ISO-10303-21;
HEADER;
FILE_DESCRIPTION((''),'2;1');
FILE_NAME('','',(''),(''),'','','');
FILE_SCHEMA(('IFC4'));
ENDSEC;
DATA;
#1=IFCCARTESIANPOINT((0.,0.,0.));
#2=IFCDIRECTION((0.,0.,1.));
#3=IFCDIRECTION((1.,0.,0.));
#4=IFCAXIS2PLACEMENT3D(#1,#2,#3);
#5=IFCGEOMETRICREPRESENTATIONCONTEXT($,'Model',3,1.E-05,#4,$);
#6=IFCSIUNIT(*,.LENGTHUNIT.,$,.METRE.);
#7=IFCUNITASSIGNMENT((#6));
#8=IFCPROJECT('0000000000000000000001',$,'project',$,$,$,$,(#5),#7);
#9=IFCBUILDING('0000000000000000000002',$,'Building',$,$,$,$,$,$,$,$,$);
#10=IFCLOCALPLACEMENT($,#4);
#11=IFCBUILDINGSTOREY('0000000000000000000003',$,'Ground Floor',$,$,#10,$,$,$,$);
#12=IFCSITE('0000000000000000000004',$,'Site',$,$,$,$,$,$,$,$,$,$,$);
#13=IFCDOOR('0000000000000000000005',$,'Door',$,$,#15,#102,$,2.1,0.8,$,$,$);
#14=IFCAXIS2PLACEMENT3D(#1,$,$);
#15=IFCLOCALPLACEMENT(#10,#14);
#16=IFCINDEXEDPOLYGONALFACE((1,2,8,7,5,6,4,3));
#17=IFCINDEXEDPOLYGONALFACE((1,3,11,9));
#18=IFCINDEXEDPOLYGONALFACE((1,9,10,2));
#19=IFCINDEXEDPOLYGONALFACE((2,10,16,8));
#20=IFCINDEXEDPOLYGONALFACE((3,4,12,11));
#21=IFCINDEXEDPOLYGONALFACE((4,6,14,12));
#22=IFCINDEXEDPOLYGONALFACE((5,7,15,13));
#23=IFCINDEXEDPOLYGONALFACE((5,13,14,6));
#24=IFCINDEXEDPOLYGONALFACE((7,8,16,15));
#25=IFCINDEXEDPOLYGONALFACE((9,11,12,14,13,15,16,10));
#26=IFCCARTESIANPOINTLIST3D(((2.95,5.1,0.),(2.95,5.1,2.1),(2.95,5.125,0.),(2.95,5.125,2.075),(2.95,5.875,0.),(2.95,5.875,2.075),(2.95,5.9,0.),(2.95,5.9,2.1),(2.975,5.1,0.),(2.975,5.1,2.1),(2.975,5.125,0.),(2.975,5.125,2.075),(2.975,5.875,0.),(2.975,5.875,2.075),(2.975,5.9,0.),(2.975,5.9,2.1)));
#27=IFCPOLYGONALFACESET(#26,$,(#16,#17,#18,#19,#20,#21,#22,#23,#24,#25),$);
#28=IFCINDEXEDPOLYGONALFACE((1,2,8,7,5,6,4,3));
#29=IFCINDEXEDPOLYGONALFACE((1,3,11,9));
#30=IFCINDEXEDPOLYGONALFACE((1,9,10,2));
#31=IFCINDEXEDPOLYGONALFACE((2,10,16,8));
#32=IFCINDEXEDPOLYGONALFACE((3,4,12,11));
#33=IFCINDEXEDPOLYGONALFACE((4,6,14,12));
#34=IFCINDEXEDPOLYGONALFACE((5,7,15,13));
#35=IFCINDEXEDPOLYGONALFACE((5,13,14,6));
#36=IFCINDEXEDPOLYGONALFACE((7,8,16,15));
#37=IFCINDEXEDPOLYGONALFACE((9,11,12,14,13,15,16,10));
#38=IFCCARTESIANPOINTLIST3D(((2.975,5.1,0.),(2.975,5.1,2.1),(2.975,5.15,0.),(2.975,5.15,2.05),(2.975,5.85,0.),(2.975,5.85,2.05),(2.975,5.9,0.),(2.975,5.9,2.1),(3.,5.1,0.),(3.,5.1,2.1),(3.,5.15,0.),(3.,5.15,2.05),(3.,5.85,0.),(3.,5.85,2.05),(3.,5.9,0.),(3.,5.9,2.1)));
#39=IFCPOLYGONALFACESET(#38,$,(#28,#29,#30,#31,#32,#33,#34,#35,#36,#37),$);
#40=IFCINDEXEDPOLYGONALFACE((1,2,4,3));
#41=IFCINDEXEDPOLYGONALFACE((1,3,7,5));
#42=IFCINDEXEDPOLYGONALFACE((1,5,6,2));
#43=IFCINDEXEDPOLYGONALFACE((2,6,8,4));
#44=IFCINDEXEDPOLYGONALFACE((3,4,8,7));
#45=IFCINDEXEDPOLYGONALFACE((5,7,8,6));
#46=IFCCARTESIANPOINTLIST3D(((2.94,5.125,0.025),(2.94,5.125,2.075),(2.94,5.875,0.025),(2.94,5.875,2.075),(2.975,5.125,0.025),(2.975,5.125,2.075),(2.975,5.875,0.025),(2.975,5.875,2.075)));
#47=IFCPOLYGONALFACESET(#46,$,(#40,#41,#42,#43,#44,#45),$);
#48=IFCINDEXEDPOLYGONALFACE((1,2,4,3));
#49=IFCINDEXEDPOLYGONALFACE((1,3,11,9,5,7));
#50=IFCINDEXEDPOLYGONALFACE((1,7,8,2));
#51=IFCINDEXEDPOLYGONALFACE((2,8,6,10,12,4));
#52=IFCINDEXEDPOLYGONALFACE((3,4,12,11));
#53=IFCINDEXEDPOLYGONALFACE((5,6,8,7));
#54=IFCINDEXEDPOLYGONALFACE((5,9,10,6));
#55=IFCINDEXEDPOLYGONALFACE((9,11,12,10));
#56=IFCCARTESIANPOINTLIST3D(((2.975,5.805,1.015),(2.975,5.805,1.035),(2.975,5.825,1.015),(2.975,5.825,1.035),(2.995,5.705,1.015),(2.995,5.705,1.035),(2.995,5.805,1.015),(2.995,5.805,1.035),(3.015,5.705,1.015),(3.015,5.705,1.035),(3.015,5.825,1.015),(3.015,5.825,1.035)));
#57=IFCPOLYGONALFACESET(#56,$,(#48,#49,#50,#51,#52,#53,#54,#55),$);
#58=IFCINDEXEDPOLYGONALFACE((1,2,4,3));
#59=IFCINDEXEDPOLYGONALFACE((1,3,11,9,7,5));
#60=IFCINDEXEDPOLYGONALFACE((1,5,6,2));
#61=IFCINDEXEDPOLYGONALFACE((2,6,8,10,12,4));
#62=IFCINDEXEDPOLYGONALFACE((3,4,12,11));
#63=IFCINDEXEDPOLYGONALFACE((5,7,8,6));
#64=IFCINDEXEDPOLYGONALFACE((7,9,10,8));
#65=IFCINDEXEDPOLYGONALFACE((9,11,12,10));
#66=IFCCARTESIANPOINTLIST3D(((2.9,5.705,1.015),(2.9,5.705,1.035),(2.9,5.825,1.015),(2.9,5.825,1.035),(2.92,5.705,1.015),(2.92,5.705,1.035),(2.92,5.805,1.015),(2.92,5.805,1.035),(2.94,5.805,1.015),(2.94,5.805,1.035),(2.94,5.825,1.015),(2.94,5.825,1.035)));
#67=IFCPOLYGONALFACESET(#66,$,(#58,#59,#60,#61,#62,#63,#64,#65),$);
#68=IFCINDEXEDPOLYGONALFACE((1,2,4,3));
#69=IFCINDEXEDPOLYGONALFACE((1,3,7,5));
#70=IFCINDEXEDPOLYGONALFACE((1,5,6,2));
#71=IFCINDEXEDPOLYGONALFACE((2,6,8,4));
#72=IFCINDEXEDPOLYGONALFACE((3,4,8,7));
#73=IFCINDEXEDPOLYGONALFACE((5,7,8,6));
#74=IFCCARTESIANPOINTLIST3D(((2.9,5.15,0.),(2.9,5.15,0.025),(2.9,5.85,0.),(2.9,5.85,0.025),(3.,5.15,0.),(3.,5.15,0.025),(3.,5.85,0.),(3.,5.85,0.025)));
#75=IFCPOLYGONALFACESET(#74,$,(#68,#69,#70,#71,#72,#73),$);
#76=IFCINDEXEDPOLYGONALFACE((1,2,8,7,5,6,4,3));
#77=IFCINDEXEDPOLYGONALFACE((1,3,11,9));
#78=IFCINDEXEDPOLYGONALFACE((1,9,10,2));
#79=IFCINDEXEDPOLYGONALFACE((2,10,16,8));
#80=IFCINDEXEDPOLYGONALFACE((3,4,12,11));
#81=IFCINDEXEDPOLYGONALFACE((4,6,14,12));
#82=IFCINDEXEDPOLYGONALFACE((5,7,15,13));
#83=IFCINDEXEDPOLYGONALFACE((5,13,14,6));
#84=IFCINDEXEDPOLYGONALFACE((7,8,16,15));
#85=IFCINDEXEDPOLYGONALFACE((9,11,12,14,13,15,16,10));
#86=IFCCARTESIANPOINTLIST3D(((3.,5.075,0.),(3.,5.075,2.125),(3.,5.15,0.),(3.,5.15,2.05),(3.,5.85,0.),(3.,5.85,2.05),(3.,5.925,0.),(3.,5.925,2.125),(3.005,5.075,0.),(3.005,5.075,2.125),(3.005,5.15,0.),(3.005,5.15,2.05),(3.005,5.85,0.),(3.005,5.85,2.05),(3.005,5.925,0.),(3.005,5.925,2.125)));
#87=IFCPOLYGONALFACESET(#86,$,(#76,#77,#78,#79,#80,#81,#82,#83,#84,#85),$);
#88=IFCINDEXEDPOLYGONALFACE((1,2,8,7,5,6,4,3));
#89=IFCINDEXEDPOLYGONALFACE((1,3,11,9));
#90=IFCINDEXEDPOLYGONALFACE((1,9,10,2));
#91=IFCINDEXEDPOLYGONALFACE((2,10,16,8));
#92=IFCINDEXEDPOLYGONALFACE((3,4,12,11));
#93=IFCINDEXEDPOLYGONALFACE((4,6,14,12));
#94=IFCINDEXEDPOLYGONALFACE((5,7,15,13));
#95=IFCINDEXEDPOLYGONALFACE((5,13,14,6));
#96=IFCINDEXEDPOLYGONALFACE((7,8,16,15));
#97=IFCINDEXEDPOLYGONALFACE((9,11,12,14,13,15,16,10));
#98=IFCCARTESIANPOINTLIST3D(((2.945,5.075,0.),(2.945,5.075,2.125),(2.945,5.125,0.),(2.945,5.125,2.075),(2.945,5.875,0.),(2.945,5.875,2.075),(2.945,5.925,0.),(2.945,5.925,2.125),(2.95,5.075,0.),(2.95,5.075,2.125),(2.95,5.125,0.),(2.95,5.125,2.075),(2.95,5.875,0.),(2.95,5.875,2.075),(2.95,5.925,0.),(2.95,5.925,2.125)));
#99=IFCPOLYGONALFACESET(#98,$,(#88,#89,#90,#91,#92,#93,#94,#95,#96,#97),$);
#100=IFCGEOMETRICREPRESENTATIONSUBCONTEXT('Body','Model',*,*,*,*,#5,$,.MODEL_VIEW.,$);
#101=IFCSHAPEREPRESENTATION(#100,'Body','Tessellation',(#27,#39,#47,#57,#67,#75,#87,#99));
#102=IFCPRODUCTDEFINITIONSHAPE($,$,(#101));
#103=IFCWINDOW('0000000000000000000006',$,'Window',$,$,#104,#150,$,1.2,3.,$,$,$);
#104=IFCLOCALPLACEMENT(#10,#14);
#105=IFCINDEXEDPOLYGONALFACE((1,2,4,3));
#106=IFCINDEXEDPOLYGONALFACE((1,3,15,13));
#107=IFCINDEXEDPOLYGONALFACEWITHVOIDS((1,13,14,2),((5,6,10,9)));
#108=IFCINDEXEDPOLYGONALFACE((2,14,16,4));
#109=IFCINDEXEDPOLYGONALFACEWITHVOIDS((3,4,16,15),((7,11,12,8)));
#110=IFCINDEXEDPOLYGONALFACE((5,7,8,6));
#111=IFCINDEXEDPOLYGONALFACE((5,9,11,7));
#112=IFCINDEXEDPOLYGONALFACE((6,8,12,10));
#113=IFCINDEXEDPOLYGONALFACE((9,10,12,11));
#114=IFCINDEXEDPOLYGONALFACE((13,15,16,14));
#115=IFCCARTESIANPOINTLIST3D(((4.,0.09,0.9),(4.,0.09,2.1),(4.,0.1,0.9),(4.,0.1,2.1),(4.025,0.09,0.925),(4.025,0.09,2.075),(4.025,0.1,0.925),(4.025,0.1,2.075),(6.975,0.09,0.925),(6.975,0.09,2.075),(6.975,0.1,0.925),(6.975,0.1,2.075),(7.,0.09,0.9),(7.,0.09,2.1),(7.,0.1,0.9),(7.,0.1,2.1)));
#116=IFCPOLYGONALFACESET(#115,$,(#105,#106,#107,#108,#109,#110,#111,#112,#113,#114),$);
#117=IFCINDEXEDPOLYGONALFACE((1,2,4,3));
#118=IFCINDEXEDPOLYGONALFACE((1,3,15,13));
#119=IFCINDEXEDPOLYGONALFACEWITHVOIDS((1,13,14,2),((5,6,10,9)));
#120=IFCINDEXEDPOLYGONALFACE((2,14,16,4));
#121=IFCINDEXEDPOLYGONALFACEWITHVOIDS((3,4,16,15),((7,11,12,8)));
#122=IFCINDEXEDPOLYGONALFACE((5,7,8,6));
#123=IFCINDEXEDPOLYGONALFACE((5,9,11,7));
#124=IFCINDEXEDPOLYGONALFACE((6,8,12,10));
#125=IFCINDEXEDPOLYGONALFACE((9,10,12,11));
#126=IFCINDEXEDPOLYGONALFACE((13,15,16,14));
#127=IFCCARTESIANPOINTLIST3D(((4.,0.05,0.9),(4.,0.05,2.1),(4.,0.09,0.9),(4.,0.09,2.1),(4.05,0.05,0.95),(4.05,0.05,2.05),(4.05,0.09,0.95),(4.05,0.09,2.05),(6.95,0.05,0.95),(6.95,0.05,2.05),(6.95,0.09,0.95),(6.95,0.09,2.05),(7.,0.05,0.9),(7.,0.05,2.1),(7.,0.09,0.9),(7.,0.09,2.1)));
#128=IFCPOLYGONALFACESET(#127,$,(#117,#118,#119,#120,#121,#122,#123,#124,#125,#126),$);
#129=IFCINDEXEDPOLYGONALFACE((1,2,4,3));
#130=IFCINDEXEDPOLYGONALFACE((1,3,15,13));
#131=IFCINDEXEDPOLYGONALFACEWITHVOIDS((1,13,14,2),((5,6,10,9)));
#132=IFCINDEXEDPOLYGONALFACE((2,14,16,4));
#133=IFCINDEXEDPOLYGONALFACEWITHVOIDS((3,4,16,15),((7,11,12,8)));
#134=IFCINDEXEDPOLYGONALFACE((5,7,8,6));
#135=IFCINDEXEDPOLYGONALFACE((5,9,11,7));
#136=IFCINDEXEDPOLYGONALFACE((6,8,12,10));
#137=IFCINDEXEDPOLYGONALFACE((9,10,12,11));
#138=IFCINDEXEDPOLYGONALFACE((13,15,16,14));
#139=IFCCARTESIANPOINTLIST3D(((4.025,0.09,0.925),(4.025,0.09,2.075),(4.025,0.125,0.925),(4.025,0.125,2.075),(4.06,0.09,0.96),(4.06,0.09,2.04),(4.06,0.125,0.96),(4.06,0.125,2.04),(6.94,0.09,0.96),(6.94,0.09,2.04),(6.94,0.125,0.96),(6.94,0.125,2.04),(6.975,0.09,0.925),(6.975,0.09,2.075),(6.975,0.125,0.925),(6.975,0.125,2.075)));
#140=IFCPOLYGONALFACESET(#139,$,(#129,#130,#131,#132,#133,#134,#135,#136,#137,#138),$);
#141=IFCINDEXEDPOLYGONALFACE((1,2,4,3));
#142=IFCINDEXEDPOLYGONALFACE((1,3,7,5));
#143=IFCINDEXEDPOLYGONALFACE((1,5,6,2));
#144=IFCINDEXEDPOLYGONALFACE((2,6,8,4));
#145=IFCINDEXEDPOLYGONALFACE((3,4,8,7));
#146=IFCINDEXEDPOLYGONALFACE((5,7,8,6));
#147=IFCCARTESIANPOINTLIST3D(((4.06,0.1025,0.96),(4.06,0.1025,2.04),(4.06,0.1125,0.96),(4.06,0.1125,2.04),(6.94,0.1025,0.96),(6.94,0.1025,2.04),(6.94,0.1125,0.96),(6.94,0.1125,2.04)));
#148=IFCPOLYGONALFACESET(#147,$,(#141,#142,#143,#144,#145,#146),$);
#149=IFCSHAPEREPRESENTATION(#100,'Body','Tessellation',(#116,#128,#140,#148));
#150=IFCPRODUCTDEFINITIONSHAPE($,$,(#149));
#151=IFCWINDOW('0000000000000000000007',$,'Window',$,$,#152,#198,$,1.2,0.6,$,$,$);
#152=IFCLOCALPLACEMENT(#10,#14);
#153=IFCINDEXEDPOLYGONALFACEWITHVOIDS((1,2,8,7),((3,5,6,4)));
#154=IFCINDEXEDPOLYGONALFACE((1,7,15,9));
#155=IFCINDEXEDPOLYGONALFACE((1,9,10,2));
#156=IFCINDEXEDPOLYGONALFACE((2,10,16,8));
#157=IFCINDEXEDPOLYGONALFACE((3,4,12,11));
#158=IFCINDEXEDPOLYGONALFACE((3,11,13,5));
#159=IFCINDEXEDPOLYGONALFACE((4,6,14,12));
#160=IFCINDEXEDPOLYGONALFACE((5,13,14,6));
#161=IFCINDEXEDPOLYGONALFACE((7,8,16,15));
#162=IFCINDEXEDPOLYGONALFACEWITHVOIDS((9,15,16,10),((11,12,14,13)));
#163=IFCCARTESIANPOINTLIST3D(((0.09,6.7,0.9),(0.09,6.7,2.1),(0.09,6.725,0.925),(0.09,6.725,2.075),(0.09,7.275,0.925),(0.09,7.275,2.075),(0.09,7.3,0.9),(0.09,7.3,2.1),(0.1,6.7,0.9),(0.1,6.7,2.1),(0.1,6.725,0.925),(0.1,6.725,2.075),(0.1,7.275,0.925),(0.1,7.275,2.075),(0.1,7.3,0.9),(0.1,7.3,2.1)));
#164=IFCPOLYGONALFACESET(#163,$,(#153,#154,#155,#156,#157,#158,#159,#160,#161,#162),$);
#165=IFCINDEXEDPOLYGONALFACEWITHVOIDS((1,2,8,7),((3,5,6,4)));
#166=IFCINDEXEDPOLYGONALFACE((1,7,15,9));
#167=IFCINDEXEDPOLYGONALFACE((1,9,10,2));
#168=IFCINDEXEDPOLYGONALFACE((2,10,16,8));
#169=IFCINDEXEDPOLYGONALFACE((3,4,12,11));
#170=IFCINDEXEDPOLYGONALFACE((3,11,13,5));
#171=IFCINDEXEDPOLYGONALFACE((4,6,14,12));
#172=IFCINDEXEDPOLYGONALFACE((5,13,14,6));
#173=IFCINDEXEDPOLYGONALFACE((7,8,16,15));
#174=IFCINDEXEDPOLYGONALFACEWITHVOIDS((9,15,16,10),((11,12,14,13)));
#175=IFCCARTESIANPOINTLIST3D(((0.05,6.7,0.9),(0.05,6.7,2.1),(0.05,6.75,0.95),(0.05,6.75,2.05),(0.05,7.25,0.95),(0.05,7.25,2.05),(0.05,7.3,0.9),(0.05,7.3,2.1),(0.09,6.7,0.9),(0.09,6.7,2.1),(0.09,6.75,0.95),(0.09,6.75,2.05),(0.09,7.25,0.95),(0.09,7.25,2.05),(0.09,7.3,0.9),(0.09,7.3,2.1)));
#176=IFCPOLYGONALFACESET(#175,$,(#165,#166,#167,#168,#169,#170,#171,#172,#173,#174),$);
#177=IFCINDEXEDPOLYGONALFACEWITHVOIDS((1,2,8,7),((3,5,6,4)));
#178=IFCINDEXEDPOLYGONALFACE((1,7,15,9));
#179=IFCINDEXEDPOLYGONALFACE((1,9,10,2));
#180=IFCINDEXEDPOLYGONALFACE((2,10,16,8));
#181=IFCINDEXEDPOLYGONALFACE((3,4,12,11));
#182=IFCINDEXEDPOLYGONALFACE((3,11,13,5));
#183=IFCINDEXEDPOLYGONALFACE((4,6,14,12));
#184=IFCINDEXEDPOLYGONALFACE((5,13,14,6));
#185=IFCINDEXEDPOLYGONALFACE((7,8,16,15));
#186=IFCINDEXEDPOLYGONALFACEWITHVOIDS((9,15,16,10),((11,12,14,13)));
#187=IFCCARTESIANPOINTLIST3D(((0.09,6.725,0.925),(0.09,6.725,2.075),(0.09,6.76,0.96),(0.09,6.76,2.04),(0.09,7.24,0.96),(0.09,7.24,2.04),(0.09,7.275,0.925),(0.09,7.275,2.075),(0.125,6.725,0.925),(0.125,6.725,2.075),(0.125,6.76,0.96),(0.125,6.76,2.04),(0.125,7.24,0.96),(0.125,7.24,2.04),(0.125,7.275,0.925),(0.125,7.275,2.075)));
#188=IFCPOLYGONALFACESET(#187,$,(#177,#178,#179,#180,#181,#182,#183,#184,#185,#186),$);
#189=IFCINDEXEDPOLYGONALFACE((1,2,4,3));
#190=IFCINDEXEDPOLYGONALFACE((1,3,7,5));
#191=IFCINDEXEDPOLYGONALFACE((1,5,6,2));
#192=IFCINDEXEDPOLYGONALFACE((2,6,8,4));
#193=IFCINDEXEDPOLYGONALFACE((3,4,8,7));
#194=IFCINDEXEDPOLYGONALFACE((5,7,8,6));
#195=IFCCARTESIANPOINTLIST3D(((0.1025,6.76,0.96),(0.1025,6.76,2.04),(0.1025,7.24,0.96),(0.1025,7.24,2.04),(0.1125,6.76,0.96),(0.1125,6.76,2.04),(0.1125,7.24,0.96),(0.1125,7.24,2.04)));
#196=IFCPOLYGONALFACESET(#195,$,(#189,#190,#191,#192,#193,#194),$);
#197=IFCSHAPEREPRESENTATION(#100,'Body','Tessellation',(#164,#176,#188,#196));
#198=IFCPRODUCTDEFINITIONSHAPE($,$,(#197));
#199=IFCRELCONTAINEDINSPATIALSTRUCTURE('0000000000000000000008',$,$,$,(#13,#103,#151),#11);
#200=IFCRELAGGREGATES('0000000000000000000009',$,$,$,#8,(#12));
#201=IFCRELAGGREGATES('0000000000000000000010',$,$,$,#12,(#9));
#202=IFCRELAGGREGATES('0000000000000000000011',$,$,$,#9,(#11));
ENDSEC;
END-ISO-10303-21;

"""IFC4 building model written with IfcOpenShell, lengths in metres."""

from ifc_helpers import new_model, si_unit, frame, origin_with_axes, place, context, subcontext, project, spatial, line, indexed_curve, outline, extrude, element, save


model = new_model("IFC4")

# Units and contexts
model_context = context("Model", 3, precision=1e-05, world=origin_with_axes())
body_context = subcontext(model_context, "Body", "Model", "MODEL_VIEW")
ifc_project = project(units=[si_unit("LENGTHUNIT", "METRE")], contexts=[model_context])

# Site, building, storey
site = spatial("IfcSite", under=ifc_project, Name="Site")
building = spatial("IfcBuilding", under=site, Name="Building")
storey_placement = place(None, origin_with_axes())
storey = spatial("IfcBuildingStorey", under=building, at=storey_placement, Name="Ground Floor")

# Door
door_1_placement = place(storey_placement, frame((3.0, 5.1, 0.0), z_axis=(0.0, 0.0, 1.0), x_axis=(0.0, 1.0, 0.0)))
element("IfcDoor", 1, at=door_1_placement, inside=storey, Name="Door", OverallHeight=2.1, OverallWidth=0.8, context=body_context, shape_type="SweptSolid", body=[
    extrude(outline(indexed_curve([(0.0, 0.0), (0.0, 2.1), (0.8, 2.1), (0.8, 0.0), (0.775, 0.0), (0.775, 2.075), (0.025, 2.075), (0.025, 0.0)], segments=[line(1, 2, 3, 4, 5, 6, 7, 8, 1)])), frame((0.0, 0.025, 0.0), z_axis=(0.0, -1.0, 0.0), x_axis=(1.0, 0.0, 0.0)), (0.0, 0.0, -1.0), 0.025),
    extrude(outline(indexed_curve([(0.0, 0.0), (0.0, 2.1), (0.8, 2.1), (0.8, 0.0), (0.75, 0.0), (0.75, 2.05), (0.05, 2.05), (0.05, 0.0)], segments=[line(1, 2, 3, 4, 5, 6, 7, 8, 1)])), frame((0.0, 0.0, 0.0), z_axis=(0.0, -1.0, 0.0), x_axis=(1.0, 0.0, 0.0)), (0.0, 0.0, -1.0), 0.025),
    extrude(outline(indexed_curve([(0.0, 0.0), (0.75, 0.0), (0.75, 0.035), (0.0, 0.035)], segments=[line(1, 2, 3, 4, 1)])), frame((0.025, 0.025, 0.025), z_axis=(0.0, 0.0, 1.0), x_axis=(1.0, 0.0, 0.0)), (0.0, 0.0, 1.0), 2.05),
    extrude(outline(indexed_curve([(0.0, 0.0), (0.0, -0.04), (-0.12, -0.04), (-0.12, -0.02), (-0.02, -0.02), (-0.02, 0.0)], segments=[line(1, 2, 3, 4, 5, 6, 1)])), frame((0.725, 0.025, 1.015), z_axis=(0.0, 0.0, 1.0), x_axis=(1.0, 0.0, 0.0)), (0.0, 0.0, 1.0), 0.02),
    extrude(outline(indexed_curve([(0.0, 0.0), (0.0, 0.04), (-0.12, 0.04), (-0.12, 0.02), (-0.02, 0.02), (-0.02, 0.0)], segments=[line(1, 2, 3, 4, 5, 6, 1)])), frame((0.725, 0.06, 1.015), z_axis=(0.0, 0.0, 1.0), x_axis=(1.0, 0.0, 0.0)), (0.0, 0.0, 1.0), 0.02),
    extrude(outline(indexed_curve([(0.0, 0.0), (0.7, 0.0), (0.7, 0.1), (0.0, 0.1)], segments=[line(1, 2, 3, 4, 1)])), frame((0.05, 0.0, 0.0), z_axis=(0.0, 0.0, 1.0), x_axis=(1.0, 0.0, 0.0)), (0.0, 0.0, 1.0), 0.025),
    extrude(outline(indexed_curve([(0.0, 0.0), (0.0, 2.125), (0.85, 2.125), (0.85, 0.0), (0.775, 0.0), (0.775, 2.05), (0.075, 2.05), (0.075, 0.0)], segments=[line(1, 2, 3, 4, 5, 6, 7, 8, 1)])), frame((-0.025, -0.005, 0.0), z_axis=(0.0, -1.0, 0.0), x_axis=(1.0, 0.0, 0.0)), (0.0, 0.0, -1.0), 0.005),
    extrude(outline(indexed_curve([(0.0, 0.0), (0.0, 2.125), (0.85, 2.125), (0.85, 0.0), (0.8, 0.0), (0.8, 2.075), (0.05, 2.075), (0.05, 0.0)], segments=[line(1, 2, 3, 4, 5, 6, 7, 8, 1)])), frame((-0.025, 0.05, 0.0), z_axis=(0.0, -1.0, 0.0), x_axis=(1.0, 0.0, 0.0)), (0.0, 0.0, -1.0), 0.005),
])

# Windows
window_1_placement = place(storey_placement, frame((4.0, 0.0, 0.9), z_axis=(0.0, 0.0, 1.0), x_axis=(1.0, 0.0, 0.0)))
element("IfcWindow", 2, at=window_1_placement, inside=storey, Name="Window", OverallHeight=1.2, OverallWidth=3.0, context=body_context, shape_type="SweptSolid", body=[
    extrude(outline(indexed_curve([(0.0, 0.0), (3.0, 0.0), (3.0, 1.2), (0.0, 1.2)], segments=[line(1, 2, 3, 4, 1)]), holes=[indexed_curve([(0.025, 0.025), (2.975, 0.025), (2.975, 1.175), (0.025, 1.175)], segments=[line(1, 2, 3, 4, 1)])]), frame((0.0, 0.09, 0.0), z_axis=(0.0, -1.0, 0.0), x_axis=(1.0, 0.0, 0.0)), (0.0, 0.0, -1.0), 0.01),
    extrude(outline(indexed_curve([(0.0, 0.0), (3.0, 0.0), (3.0, 1.2), (0.0, 1.2)], segments=[line(1, 2, 3, 4, 1)]), holes=[indexed_curve([(0.05, 0.05), (2.95, 0.05), (2.95, 1.15), (0.05, 1.15)], segments=[line(1, 2, 3, 4, 1)])]), frame((0.0, 0.05, 0.0), z_axis=(0.0, -1.0, 0.0), x_axis=(1.0, 0.0, 0.0)), (0.0, 0.0, -1.0), 0.04),
    extrude(outline(indexed_curve([(0.0, 0.0), (2.95, 0.0), (2.95, 1.15), (0.0, 1.15)], segments=[line(1, 2, 3, 4, 1)]), holes=[indexed_curve([(0.035, 0.035), (2.915, 0.035), (2.915, 1.115), (0.035, 1.115)], segments=[line(1, 2, 3, 4, 1)])]), frame((0.025, 0.09, 0.025), z_axis=(0.0, -1.0, 0.0), x_axis=(1.0, 0.0, 0.0)), (0.0, 0.0, -1.0), 0.035),
    extrude(outline(indexed_curve([(0.035, 0.035), (2.915, 0.035), (2.915, 1.115), (0.035, 1.115)], segments=[line(1, 2, 3, 4, 1)])), frame((0.025, 0.1025, 0.025), z_axis=(0.0, -1.0, 0.0), x_axis=(1.0, 0.0, 0.0)), (0.0, 0.0, -1.0), 0.01),
])
for number, where, z_axis, x_axis, name in (
    (3, (0.0, 7.3, 0.9), (0.0, 0.0, 1.0), (0.0, -1.0, 0.0), "Window"),
):
    element("IfcWindow", number, at=place(storey_placement, frame(where, z_axis=z_axis, x_axis=x_axis)), inside=storey, Name=name, OverallHeight=1.2, OverallWidth=0.6, context=body_context, shape_type="SweptSolid", body=[
        extrude(outline(indexed_curve([(0.0, 0.0), (0.6, 0.0), (0.6, 1.2), (0.0, 1.2)], segments=[line(1, 2, 3, 4, 1)]), holes=[indexed_curve([(0.025, 0.025), (0.575, 0.025), (0.575, 1.175), (0.025, 1.175)], segments=[line(1, 2, 3, 4, 1)])]), frame((0.0, 0.09, 0.0), z_axis=(0.0, -1.0, 0.0), x_axis=(1.0, 0.0, 0.0)), (0.0, 0.0, -1.0), 0.01),
        extrude(outline(indexed_curve([(0.0, 0.0), (0.6, 0.0), (0.6, 1.2), (0.0, 1.2)], segments=[line(1, 2, 3, 4, 1)]), holes=[indexed_curve([(0.05, 0.05), (0.55, 0.05), (0.55, 1.15), (0.05, 1.15)], segments=[line(1, 2, 3, 4, 1)])]), frame((0.0, 0.05, 0.0), z_axis=(0.0, -1.0, 0.0), x_axis=(1.0, 0.0, 0.0)), (0.0, 0.0, -1.0), 0.04),
        extrude(outline(indexed_curve([(0.0, 0.0), (0.55, 0.0), (0.55, 1.15), (0.0, 1.15)], segments=[line(1, 2, 3, 4, 1)]), holes=[indexed_curve([(0.035, 0.035), (0.515, 0.035), (0.515, 1.115), (0.035, 1.115)], segments=[line(1, 2, 3, 4, 1)])]), frame((0.025, 0.09, 0.025), z_axis=(0.0, -1.0, 0.0), x_axis=(1.0, 0.0, 0.0)), (0.0, 0.0, -1.0), 0.035),
        extrude(outline(indexed_curve([(0.035, 0.035), (0.515, 0.035), (0.515, 1.115), (0.035, 1.115)], segments=[line(1, 2, 3, 4, 1)])), frame((0.025, 0.1025, 0.025), z_axis=(0.0, -1.0, 0.0), x_axis=(1.0, 0.0, 0.0)), (0.0, 0.0, -1.0), 0.01),
    ])

save(model, "model.ifc")
